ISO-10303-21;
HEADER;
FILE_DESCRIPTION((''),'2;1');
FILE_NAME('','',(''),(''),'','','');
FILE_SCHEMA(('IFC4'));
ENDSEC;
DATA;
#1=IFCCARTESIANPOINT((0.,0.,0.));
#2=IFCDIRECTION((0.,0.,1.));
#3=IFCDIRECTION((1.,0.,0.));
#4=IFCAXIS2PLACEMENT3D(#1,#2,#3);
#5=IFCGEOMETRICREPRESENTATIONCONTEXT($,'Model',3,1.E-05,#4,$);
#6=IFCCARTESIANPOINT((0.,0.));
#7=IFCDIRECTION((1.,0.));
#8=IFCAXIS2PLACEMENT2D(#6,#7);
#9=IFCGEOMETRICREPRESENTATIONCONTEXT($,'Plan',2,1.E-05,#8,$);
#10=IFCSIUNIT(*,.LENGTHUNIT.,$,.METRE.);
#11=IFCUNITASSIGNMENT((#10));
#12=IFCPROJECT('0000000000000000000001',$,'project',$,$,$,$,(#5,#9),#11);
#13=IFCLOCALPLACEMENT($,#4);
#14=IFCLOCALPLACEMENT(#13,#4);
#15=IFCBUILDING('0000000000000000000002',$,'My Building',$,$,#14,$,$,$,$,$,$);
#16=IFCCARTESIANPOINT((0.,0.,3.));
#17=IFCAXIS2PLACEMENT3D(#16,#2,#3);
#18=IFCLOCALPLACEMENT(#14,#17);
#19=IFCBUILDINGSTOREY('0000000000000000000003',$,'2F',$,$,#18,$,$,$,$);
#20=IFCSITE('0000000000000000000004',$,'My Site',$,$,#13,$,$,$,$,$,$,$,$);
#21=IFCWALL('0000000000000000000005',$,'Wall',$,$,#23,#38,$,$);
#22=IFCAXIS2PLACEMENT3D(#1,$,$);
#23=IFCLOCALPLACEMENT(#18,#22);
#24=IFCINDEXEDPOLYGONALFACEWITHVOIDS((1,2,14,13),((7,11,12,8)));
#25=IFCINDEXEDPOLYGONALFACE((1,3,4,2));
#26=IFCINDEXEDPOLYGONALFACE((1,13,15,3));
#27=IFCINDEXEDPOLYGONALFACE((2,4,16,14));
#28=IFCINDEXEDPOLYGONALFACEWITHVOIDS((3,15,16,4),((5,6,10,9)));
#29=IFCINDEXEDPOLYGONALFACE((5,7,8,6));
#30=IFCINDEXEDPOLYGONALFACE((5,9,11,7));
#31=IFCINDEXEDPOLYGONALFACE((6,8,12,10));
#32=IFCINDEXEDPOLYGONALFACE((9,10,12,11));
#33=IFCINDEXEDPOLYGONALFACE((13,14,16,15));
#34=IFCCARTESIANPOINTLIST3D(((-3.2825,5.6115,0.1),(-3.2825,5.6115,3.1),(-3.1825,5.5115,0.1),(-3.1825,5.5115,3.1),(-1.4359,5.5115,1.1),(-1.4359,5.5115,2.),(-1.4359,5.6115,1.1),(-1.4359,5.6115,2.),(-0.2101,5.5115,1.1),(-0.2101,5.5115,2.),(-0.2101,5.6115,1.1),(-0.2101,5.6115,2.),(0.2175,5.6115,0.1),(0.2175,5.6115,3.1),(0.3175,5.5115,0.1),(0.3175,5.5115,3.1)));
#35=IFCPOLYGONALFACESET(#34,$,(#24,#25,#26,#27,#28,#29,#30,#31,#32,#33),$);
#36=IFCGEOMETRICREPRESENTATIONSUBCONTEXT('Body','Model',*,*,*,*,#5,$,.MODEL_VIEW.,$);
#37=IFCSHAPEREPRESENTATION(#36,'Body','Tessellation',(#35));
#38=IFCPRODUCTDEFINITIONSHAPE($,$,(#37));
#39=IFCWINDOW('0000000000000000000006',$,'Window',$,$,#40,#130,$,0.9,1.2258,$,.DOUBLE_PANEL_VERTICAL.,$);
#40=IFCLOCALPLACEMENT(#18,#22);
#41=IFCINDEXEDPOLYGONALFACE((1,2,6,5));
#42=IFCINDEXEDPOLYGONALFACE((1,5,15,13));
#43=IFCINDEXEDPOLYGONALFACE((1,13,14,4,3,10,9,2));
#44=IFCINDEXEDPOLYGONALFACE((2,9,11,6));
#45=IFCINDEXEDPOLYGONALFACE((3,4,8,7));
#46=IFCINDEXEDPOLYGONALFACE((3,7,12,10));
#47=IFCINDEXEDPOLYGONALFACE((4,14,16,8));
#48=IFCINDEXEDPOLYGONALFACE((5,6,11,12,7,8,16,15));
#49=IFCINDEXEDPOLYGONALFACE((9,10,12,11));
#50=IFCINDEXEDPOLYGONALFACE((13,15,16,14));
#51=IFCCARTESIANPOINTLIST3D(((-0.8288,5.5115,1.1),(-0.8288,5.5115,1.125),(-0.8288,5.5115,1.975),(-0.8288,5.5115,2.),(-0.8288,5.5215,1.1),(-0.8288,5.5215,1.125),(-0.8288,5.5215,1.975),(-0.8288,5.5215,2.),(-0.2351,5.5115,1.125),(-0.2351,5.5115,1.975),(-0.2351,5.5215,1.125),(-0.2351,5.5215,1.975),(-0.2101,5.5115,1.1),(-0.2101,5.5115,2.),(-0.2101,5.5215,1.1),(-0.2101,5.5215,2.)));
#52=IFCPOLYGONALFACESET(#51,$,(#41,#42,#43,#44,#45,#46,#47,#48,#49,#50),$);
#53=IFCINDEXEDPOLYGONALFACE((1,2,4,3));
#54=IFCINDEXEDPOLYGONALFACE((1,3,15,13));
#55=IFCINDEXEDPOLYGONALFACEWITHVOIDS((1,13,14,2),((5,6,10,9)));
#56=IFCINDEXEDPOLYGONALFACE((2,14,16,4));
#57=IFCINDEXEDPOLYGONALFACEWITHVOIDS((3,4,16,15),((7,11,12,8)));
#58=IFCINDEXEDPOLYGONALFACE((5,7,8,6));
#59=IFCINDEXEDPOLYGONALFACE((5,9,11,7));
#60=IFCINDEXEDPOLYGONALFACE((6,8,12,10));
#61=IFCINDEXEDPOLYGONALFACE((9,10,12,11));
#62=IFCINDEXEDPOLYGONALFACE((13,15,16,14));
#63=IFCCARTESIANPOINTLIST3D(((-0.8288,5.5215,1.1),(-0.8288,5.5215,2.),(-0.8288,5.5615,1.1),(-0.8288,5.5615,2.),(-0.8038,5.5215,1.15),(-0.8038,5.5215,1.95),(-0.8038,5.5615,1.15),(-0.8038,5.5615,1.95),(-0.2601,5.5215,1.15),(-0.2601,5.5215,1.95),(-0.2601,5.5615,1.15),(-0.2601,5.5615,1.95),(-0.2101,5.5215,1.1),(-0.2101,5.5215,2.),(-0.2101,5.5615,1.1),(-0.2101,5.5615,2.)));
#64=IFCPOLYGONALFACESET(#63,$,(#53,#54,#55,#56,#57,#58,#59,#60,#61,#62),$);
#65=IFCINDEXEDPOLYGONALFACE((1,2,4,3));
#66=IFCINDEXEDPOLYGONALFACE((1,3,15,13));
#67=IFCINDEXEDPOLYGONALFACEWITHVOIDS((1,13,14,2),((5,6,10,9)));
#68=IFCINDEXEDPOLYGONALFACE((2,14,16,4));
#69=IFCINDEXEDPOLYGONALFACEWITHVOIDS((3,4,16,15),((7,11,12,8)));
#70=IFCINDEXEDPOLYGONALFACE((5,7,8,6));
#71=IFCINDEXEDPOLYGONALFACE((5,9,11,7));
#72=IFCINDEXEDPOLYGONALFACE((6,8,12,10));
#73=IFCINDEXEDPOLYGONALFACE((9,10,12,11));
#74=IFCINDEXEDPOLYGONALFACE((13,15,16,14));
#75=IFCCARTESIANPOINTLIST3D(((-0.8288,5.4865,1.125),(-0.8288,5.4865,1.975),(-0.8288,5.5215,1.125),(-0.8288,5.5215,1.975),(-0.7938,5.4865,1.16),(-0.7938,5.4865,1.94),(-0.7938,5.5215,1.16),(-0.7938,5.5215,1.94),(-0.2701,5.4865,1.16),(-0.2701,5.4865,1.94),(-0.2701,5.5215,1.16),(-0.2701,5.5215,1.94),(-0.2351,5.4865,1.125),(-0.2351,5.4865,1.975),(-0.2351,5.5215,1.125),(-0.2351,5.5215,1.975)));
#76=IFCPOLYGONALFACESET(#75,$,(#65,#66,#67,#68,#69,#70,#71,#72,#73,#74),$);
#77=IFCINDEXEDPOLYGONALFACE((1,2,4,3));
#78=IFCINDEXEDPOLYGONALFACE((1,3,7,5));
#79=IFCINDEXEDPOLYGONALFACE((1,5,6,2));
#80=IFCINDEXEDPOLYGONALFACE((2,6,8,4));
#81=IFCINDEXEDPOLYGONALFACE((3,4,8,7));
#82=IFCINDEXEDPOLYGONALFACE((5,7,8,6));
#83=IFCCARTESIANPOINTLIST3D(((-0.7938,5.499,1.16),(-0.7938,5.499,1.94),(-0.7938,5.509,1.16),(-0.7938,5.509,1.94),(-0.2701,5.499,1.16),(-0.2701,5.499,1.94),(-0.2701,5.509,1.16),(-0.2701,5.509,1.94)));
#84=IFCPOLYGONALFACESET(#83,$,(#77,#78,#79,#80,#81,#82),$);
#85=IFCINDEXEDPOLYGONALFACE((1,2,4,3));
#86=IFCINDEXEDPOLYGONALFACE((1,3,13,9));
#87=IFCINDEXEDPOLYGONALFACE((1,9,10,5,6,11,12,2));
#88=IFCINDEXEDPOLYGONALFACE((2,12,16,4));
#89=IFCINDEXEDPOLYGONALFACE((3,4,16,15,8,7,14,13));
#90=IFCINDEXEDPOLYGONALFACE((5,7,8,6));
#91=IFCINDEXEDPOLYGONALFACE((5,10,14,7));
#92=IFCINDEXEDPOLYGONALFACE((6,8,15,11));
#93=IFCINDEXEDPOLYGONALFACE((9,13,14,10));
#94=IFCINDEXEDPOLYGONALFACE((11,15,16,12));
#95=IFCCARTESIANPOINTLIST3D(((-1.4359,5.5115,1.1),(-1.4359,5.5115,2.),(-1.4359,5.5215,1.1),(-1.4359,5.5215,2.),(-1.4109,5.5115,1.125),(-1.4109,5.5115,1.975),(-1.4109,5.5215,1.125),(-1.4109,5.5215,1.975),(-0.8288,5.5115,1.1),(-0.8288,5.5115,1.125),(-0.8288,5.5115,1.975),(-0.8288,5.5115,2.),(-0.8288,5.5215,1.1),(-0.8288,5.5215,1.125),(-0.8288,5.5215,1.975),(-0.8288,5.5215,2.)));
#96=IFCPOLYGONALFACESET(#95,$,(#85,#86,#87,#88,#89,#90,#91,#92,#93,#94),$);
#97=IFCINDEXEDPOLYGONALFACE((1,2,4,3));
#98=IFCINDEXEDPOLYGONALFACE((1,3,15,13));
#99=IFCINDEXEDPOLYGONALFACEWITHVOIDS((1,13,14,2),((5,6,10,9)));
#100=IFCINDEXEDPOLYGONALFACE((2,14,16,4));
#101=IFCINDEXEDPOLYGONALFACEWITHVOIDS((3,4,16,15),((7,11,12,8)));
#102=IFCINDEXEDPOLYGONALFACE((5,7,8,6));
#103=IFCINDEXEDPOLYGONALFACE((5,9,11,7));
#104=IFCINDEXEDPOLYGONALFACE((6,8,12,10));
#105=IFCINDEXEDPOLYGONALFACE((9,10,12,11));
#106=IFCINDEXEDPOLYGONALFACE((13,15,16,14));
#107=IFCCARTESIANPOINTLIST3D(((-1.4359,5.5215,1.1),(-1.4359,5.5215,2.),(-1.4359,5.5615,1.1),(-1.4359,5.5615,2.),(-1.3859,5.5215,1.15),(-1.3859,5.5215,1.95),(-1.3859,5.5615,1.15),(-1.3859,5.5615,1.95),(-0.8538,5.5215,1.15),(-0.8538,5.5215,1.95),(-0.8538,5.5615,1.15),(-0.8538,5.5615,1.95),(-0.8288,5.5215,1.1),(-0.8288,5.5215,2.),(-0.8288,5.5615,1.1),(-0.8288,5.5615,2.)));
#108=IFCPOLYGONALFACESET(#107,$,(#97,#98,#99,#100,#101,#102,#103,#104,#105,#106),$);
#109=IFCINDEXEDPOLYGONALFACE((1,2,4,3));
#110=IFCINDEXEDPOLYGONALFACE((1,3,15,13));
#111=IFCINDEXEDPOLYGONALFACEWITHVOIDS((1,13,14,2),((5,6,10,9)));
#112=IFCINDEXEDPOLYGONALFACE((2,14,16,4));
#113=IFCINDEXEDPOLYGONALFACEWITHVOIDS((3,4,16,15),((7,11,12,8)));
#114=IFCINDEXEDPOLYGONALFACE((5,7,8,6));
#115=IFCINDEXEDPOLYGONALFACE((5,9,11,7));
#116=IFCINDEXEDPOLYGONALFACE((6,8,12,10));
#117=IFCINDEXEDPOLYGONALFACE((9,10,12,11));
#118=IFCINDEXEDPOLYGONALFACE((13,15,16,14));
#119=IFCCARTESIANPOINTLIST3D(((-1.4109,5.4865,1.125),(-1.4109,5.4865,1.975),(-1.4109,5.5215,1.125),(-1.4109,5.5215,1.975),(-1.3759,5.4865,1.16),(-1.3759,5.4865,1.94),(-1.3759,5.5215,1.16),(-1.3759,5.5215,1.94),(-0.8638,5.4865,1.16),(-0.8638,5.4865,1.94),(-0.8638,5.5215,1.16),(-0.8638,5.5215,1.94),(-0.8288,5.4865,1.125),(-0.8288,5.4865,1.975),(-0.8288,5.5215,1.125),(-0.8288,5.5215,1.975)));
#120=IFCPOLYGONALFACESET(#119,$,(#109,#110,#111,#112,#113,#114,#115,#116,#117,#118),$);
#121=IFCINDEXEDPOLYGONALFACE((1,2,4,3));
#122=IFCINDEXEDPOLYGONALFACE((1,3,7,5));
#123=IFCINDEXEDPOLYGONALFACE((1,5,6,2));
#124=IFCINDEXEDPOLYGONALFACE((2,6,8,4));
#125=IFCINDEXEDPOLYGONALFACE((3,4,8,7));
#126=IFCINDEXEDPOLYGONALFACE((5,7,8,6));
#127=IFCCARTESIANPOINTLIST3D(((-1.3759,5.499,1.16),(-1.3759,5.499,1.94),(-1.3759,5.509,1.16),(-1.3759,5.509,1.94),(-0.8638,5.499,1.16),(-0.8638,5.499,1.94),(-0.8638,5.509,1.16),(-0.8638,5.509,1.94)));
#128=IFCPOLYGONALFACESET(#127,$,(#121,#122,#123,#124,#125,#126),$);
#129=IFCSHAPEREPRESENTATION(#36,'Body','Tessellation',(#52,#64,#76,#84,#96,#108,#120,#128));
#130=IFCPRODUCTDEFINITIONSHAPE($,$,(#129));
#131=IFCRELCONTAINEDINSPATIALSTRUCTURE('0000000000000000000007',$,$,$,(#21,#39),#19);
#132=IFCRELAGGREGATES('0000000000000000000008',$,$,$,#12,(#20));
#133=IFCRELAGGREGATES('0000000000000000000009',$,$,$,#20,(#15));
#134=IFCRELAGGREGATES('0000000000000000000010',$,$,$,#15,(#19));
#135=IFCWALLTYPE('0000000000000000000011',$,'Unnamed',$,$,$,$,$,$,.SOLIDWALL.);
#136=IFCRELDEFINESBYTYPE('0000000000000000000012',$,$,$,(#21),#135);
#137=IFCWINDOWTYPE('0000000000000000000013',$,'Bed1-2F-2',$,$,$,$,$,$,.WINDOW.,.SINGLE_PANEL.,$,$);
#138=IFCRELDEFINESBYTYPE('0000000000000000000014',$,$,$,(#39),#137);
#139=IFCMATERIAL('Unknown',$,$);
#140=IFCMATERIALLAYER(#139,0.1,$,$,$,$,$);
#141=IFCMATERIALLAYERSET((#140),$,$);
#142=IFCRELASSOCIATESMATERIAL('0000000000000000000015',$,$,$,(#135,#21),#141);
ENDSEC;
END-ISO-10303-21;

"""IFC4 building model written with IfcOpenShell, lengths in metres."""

from ifc_helpers import new_model, entity, si_unit, frame, origin_with_axes, origin_2d_with_axis, place, context, subcontext, project, spatial, line, indexed_curve, outline, extrude, shape, source, transform, mapped, material, layer, layer_set, layer_usage, type_object, type_shapes, element, fill, save


model = new_model("IFC4")

# Units and contexts
model_context = context("Model", 3, precision=1e-05, world=origin_with_axes())
plan_context = context("Plan", 2, precision=1e-05, world=origin_2d_with_axis())
body_context_1 = subcontext(model_context, "Body", "Model", "MODEL_VIEW")
body_context_2 = subcontext(plan_context, "Body", "Plan", "PLAN_VIEW")
ifc_project = project(units=[si_unit("LENGTHUNIT", "METRE")], contexts=[model_context, plan_context])

# Site, building, storey
site_placement = place(None, origin_with_axes())
site = spatial("IfcSite", under=ifc_project, at=site_placement, Name="My Site")
building_placement = place(site_placement, origin_with_axes())
building = spatial("IfcBuilding", under=site, at=building_placement, Name="My Building")
storey_placement = place(building_placement, frame((0.0, 0.0, 3.0), z_axis=(0.0, 0.0, 1.0), x_axis=(1.0, 0.0, 0.0)))
storey = spatial("IfcBuildingStorey", under=building, at=storey_placement, Name="2F")

# Shared definitions
ifc_material = material(Name="Unknown")
ifc_layer = layer(ifc_material, 0.1)
ifc_layer_set = layer_set([ifc_layer])
wall_type = type_object("IfcWallType", Name="Unnamed", PredefinedType="SOLIDWALL", material=ifc_layer_set)

# Wall, opening, window
ifc_layer_usage_1 = layer_usage(ifc_layer_set, "AXIS2", "POSITIVE", 0.0)
wall_1_placement = place(storey_placement, frame((-3.1825, 5.5115, 0.1), z_axis=(0.0, 0.0, 1.0), x_axis=(1.0, 0.0, 0.0)))
wall_1 = element("IfcWall", 1, at=wall_1_placement, inside=storey, type_object=wall_type, material=ifc_layer_usage_1, Name="Wall", context=body_context_1, shape_type="SweptSolid", body=[
    extrude(outline(indexed_curve([(0.0, 0.0), (-0.1, 0.1), (3.4, 0.1), (3.5, 0.0)], segments=[line(1, 2, 3, 4, 1)])), origin_with_axes(), (0.0, 0.0, 1.0), 3.0),
])
shared_shape_1 = source(origin_with_axes(), body_context_1, "Body", "SweptSolid", [
    extrude(outline(indexed_curve([(0.0, 0.0), (1.2258, 0.0), (1.2258, 0.9), (0.0, 0.9)], segments=[line(1, 2, 3, 4, 1)])), frame((0.0, -0.6, 0.0), z_axis=(0.0, -1.0, 0.0), x_axis=(1.0, 0.0, 0.0)), (0.0, 0.0, -1.0), 1.2),
])
opening_1_placement = place(wall_1_placement, frame((2.9724, 0.1, 1.0), z_axis=(0.0, 0.0, 1.0), x_axis=(-1.0, 0.0, 0.0)))
opening_1 = element("IfcOpeningElement", 2, at=opening_1_placement, cuts=wall_1, PredefinedType="OPENING", context=body_context_1, shape_type="MappedRepresentation", body=[
    mapped(shared_shape_1, transform((0.0, 0.0, 0.0), x_axis=(1.0, 0.0, 0.0), y_axis=(0.0, 1.0, 0.0), z_axis=(0.0, 0.0, 1.0), scale=1.0)),
])
window_type_1 = type_object("IfcWindowType", Name="Bed1-2F-2", PartitioningType="SINGLE_PANEL", PredefinedType="WINDOW")
shared_shape_2 = source(origin_with_axes(), body_context_1, "Body", "SweptSolid", [
    extrude(outline(indexed_curve([(0.6187, 0.0), (0.0, 0.0), (0.0, 0.9), (0.6187, 0.9), (0.6187, 0.875), (0.025, 0.875), (0.025, 0.025), (0.6187, 0.025)], segments=[line(1, 2, 3, 4, 5, 6, 7, 8, 1)])), frame((0.0, 0.09, 0.0), z_axis=(0.0, -1.0, 0.0), x_axis=(1.0, 0.0, 0.0)), (0.0, 0.0, -1.0), 0.01),
    extrude(outline(indexed_curve([(0.0, 0.0), (0.6187, 0.0), (0.6187, 0.9), (0.0, 0.9)], segments=[line(1, 2, 3, 4, 1)]), holes=[indexed_curve([(0.05, 0.05), (0.5937, 0.05), (0.5937, 0.85), (0.05, 0.85)], segments=[line(1, 2, 3, 4, 1)])]), frame((0.0, 0.05, 0.0), z_axis=(0.0, -1.0, 0.0), x_axis=(1.0, 0.0, 0.0)), (0.0, 0.0, -1.0), 0.04),
    extrude(outline(indexed_curve([(0.0, 0.0), (0.5937, 0.0), (0.5937, 0.85), (0.0, 0.85)], segments=[line(1, 2, 3, 4, 1)]), holes=[indexed_curve([(0.035, 0.035), (0.5587, 0.035), (0.5587, 0.815), (0.035, 0.815)], segments=[line(1, 2, 3, 4, 1)])]), frame((0.025, 0.09, 0.025), z_axis=(0.0, -1.0, 0.0), x_axis=(1.0, 0.0, 0.0)), (0.0, 0.0, -1.0), 0.035),
    extrude(outline(indexed_curve([(0.035, 0.035), (0.5587, 0.035), (0.5587, 0.815), (0.035, 0.815)], segments=[line(1, 2, 3, 4, 1)])), frame((0.025, 0.1025, 0.025), z_axis=(0.0, -1.0, 0.0), x_axis=(1.0, 0.0, 0.0)), (0.0, 0.0, -1.0), 0.01),
    extrude(outline(indexed_curve([(0.0, 0.9), (0.6071, 0.9), (0.6071, 0.0), (0.0, 0.0), (0.0, 0.025), (0.5821, 0.025), (0.5821, 0.875), (0.0, 0.875)], segments=[line(1, 2, 3, 4, 5, 6, 7, 8, 1)])), frame((0.6187, 0.09, 0.0), z_axis=(0.0, -1.0, 0.0), x_axis=(1.0, 0.0, 0.0)), (0.0, 0.0, -1.0), 0.01),
    extrude(outline(indexed_curve([(0.0, 0.0), (0.6071, 0.0), (0.6071, 0.9), (0.0, 0.9)], segments=[line(1, 2, 3, 4, 1)]), holes=[indexed_curve([(0.025, 0.05), (0.5571, 0.05), (0.5571, 0.85), (0.025, 0.85)], segments=[line(1, 2, 3, 4, 1)])]), frame((0.6187, 0.05, 0.0), z_axis=(0.0, -1.0, 0.0), x_axis=(1.0, 0.0, 0.0)), (0.0, 0.0, -1.0), 0.04),
    extrude(outline(indexed_curve([(0.0, 0.0), (0.5821, 0.0), (0.5821, 0.85), (0.0, 0.85)], segments=[line(1, 2, 3, 4, 1)]), holes=[indexed_curve([(0.035, 0.035), (0.5471, 0.035), (0.5471, 0.815), (0.035, 0.815)], segments=[line(1, 2, 3, 4, 1)])]), frame((0.6187, 0.09, 0.025), z_axis=(0.0, -1.0, 0.0), x_axis=(1.0, 0.0, 0.0)), (0.0, 0.0, -1.0), 0.035),
    extrude(outline(indexed_curve([(0.035, 0.035), (0.5471, 0.035), (0.5471, 0.815), (0.035, 0.815)], segments=[line(1, 2, 3, 4, 1)])), frame((0.6187, 0.1025, 0.025), z_axis=(0.0, -1.0, 0.0), x_axis=(1.0, 0.0, 0.0)), (0.0, 0.0, -1.0), 0.01),
])
shared_shape_3 = source(origin_with_axes(), body_context_2, "Body", "Curve2D", [
    entity("IfcIndexedPolyCurve", entity("IfcCartesianPointList2D", [[0.05, 0.05], [0.5937, 0.05]])),
    entity("IfcIndexedPolyCurve", entity("IfcCartesianPointList2D", [[0.0, 0.1], [0.025, 0.1], [0.025, 0.09], [0.05, 0.09], [0.05, 0.05], [0.0, 0.05]]), [entity("IfcLineIndex", [1, 2, 3, 4, 5, 6, 1])]),
    entity("IfcIndexedPolyCurve", entity("IfcCartesianPointList2D", [[0.6187, 0.1], [0.6187, 0.1], [0.6187, 0.09], [0.5937, 0.09], [0.5937, 0.05], [0.6187, 0.05]])),
    entity("IfcIndexedPolyCurve", entity("IfcCartesianPointList2D", [[0.025, 0.09], [0.06, 0.09], [0.06, 0.125], [0.025, 0.125]]), [entity("IfcLineIndex", [1, 2, 3, 4, 1])]),
    entity("IfcIndexedPolyCurve", entity("IfcCartesianPointList2D", [[0.6187, 0.09], [0.5837, 0.09], [0.5837, 0.125], [0.6187, 0.125]]), [entity("IfcLineIndex", [1, 2, 3, 4, 1])]),
    entity("IfcIndexedPolyCurve", entity("IfcCartesianPointList2D", [[0.06, 0.09], [0.5837, 0.09]])),
    entity("IfcIndexedPolyCurve", entity("IfcCartesianPointList2D", [[0.06, 0.125], [0.5837, 0.125]])),
    entity("IfcIndexedPolyCurve", entity("IfcCartesianPointList2D", [[0.06, 0.1075], [0.5837, 0.1075]])),
    entity("IfcIndexedPolyCurve", entity("IfcCartesianPointList2D", [[0.6437, 0.05], [1.1758, 0.05]])),
    entity("IfcIndexedPolyCurve", entity("IfcCartesianPointList2D", [[0.6187, 0.1], [0.6187, 0.1], [0.6187, 0.09], [0.6437, 0.09], [0.6437, 0.05], [0.6187, 0.05]])),
    entity("IfcIndexedPolyCurve", entity("IfcCartesianPointList2D", [[1.2258, 0.1], [1.2008, 0.1], [1.2008, 0.09], [1.1758, 0.09], [1.1758, 0.05], [1.2258, 0.05]]), [entity("IfcLineIndex", [1, 2, 3, 4, 5, 6, 1])]),
    entity("IfcIndexedPolyCurve", entity("IfcCartesianPointList2D", [[0.6187, 0.09], [0.6537, 0.09], [0.6537, 0.125], [0.6187, 0.125]]), [entity("IfcLineIndex", [1, 2, 3, 4, 1])]),
    entity("IfcIndexedPolyCurve", entity("IfcCartesianPointList2D", [[1.2008, 0.09], [1.1658, 0.09], [1.1658, 0.125], [1.2008, 0.125]]), [entity("IfcLineIndex", [1, 2, 3, 4, 1])]),
    entity("IfcIndexedPolyCurve", entity("IfcCartesianPointList2D", [[0.6537, 0.09], [1.1658, 0.09]])),
    entity("IfcIndexedPolyCurve", entity("IfcCartesianPointList2D", [[0.6537, 0.125], [1.1658, 0.125]])),
    entity("IfcIndexedPolyCurve", entity("IfcCartesianPointList2D", [[0.6537, 0.1075], [1.1658, 0.1075]])),
])
type_shapes(window_type_1, [shared_shape_2, shared_shape_3])
window_1_placement = place(opening_1_placement, frame((0.0, 0.0, 0.0), z_axis=(0.0, 0.0, 1.0), x_axis=(1.0, 0.0, 0.0)))
window_1 = element("IfcWindow", 3, at=window_1_placement, inside=storey, type_object=window_type_1, Name="Window", OverallHeight=0.9, OverallWidth=1.2258, PartitioningType="DOUBLE_PANEL_VERTICAL", shapes=[
    shape(body_context_1, "Body", "MappedRepresentation", [mapped(shared_shape_2, transform((0.0, 0.0, 0.0), x_axis=(1.0, 0.0, 0.0), y_axis=(0.0, 1.0, 0.0), z_axis=(0.0, 0.0, 1.0), scale=1.0))]),
    shape(body_context_2, "Body", "MappedRepresentation", [mapped(shared_shape_3, transform((0.0, 0.0, 0.0), x_axis=(1.0, 0.0, 0.0), y_axis=(0.0, 1.0, 0.0), z_axis=(0.0, 0.0, 1.0), scale=1.0))]),
])
fill(opening_1, window_1)

save(model, "model.ifc")
